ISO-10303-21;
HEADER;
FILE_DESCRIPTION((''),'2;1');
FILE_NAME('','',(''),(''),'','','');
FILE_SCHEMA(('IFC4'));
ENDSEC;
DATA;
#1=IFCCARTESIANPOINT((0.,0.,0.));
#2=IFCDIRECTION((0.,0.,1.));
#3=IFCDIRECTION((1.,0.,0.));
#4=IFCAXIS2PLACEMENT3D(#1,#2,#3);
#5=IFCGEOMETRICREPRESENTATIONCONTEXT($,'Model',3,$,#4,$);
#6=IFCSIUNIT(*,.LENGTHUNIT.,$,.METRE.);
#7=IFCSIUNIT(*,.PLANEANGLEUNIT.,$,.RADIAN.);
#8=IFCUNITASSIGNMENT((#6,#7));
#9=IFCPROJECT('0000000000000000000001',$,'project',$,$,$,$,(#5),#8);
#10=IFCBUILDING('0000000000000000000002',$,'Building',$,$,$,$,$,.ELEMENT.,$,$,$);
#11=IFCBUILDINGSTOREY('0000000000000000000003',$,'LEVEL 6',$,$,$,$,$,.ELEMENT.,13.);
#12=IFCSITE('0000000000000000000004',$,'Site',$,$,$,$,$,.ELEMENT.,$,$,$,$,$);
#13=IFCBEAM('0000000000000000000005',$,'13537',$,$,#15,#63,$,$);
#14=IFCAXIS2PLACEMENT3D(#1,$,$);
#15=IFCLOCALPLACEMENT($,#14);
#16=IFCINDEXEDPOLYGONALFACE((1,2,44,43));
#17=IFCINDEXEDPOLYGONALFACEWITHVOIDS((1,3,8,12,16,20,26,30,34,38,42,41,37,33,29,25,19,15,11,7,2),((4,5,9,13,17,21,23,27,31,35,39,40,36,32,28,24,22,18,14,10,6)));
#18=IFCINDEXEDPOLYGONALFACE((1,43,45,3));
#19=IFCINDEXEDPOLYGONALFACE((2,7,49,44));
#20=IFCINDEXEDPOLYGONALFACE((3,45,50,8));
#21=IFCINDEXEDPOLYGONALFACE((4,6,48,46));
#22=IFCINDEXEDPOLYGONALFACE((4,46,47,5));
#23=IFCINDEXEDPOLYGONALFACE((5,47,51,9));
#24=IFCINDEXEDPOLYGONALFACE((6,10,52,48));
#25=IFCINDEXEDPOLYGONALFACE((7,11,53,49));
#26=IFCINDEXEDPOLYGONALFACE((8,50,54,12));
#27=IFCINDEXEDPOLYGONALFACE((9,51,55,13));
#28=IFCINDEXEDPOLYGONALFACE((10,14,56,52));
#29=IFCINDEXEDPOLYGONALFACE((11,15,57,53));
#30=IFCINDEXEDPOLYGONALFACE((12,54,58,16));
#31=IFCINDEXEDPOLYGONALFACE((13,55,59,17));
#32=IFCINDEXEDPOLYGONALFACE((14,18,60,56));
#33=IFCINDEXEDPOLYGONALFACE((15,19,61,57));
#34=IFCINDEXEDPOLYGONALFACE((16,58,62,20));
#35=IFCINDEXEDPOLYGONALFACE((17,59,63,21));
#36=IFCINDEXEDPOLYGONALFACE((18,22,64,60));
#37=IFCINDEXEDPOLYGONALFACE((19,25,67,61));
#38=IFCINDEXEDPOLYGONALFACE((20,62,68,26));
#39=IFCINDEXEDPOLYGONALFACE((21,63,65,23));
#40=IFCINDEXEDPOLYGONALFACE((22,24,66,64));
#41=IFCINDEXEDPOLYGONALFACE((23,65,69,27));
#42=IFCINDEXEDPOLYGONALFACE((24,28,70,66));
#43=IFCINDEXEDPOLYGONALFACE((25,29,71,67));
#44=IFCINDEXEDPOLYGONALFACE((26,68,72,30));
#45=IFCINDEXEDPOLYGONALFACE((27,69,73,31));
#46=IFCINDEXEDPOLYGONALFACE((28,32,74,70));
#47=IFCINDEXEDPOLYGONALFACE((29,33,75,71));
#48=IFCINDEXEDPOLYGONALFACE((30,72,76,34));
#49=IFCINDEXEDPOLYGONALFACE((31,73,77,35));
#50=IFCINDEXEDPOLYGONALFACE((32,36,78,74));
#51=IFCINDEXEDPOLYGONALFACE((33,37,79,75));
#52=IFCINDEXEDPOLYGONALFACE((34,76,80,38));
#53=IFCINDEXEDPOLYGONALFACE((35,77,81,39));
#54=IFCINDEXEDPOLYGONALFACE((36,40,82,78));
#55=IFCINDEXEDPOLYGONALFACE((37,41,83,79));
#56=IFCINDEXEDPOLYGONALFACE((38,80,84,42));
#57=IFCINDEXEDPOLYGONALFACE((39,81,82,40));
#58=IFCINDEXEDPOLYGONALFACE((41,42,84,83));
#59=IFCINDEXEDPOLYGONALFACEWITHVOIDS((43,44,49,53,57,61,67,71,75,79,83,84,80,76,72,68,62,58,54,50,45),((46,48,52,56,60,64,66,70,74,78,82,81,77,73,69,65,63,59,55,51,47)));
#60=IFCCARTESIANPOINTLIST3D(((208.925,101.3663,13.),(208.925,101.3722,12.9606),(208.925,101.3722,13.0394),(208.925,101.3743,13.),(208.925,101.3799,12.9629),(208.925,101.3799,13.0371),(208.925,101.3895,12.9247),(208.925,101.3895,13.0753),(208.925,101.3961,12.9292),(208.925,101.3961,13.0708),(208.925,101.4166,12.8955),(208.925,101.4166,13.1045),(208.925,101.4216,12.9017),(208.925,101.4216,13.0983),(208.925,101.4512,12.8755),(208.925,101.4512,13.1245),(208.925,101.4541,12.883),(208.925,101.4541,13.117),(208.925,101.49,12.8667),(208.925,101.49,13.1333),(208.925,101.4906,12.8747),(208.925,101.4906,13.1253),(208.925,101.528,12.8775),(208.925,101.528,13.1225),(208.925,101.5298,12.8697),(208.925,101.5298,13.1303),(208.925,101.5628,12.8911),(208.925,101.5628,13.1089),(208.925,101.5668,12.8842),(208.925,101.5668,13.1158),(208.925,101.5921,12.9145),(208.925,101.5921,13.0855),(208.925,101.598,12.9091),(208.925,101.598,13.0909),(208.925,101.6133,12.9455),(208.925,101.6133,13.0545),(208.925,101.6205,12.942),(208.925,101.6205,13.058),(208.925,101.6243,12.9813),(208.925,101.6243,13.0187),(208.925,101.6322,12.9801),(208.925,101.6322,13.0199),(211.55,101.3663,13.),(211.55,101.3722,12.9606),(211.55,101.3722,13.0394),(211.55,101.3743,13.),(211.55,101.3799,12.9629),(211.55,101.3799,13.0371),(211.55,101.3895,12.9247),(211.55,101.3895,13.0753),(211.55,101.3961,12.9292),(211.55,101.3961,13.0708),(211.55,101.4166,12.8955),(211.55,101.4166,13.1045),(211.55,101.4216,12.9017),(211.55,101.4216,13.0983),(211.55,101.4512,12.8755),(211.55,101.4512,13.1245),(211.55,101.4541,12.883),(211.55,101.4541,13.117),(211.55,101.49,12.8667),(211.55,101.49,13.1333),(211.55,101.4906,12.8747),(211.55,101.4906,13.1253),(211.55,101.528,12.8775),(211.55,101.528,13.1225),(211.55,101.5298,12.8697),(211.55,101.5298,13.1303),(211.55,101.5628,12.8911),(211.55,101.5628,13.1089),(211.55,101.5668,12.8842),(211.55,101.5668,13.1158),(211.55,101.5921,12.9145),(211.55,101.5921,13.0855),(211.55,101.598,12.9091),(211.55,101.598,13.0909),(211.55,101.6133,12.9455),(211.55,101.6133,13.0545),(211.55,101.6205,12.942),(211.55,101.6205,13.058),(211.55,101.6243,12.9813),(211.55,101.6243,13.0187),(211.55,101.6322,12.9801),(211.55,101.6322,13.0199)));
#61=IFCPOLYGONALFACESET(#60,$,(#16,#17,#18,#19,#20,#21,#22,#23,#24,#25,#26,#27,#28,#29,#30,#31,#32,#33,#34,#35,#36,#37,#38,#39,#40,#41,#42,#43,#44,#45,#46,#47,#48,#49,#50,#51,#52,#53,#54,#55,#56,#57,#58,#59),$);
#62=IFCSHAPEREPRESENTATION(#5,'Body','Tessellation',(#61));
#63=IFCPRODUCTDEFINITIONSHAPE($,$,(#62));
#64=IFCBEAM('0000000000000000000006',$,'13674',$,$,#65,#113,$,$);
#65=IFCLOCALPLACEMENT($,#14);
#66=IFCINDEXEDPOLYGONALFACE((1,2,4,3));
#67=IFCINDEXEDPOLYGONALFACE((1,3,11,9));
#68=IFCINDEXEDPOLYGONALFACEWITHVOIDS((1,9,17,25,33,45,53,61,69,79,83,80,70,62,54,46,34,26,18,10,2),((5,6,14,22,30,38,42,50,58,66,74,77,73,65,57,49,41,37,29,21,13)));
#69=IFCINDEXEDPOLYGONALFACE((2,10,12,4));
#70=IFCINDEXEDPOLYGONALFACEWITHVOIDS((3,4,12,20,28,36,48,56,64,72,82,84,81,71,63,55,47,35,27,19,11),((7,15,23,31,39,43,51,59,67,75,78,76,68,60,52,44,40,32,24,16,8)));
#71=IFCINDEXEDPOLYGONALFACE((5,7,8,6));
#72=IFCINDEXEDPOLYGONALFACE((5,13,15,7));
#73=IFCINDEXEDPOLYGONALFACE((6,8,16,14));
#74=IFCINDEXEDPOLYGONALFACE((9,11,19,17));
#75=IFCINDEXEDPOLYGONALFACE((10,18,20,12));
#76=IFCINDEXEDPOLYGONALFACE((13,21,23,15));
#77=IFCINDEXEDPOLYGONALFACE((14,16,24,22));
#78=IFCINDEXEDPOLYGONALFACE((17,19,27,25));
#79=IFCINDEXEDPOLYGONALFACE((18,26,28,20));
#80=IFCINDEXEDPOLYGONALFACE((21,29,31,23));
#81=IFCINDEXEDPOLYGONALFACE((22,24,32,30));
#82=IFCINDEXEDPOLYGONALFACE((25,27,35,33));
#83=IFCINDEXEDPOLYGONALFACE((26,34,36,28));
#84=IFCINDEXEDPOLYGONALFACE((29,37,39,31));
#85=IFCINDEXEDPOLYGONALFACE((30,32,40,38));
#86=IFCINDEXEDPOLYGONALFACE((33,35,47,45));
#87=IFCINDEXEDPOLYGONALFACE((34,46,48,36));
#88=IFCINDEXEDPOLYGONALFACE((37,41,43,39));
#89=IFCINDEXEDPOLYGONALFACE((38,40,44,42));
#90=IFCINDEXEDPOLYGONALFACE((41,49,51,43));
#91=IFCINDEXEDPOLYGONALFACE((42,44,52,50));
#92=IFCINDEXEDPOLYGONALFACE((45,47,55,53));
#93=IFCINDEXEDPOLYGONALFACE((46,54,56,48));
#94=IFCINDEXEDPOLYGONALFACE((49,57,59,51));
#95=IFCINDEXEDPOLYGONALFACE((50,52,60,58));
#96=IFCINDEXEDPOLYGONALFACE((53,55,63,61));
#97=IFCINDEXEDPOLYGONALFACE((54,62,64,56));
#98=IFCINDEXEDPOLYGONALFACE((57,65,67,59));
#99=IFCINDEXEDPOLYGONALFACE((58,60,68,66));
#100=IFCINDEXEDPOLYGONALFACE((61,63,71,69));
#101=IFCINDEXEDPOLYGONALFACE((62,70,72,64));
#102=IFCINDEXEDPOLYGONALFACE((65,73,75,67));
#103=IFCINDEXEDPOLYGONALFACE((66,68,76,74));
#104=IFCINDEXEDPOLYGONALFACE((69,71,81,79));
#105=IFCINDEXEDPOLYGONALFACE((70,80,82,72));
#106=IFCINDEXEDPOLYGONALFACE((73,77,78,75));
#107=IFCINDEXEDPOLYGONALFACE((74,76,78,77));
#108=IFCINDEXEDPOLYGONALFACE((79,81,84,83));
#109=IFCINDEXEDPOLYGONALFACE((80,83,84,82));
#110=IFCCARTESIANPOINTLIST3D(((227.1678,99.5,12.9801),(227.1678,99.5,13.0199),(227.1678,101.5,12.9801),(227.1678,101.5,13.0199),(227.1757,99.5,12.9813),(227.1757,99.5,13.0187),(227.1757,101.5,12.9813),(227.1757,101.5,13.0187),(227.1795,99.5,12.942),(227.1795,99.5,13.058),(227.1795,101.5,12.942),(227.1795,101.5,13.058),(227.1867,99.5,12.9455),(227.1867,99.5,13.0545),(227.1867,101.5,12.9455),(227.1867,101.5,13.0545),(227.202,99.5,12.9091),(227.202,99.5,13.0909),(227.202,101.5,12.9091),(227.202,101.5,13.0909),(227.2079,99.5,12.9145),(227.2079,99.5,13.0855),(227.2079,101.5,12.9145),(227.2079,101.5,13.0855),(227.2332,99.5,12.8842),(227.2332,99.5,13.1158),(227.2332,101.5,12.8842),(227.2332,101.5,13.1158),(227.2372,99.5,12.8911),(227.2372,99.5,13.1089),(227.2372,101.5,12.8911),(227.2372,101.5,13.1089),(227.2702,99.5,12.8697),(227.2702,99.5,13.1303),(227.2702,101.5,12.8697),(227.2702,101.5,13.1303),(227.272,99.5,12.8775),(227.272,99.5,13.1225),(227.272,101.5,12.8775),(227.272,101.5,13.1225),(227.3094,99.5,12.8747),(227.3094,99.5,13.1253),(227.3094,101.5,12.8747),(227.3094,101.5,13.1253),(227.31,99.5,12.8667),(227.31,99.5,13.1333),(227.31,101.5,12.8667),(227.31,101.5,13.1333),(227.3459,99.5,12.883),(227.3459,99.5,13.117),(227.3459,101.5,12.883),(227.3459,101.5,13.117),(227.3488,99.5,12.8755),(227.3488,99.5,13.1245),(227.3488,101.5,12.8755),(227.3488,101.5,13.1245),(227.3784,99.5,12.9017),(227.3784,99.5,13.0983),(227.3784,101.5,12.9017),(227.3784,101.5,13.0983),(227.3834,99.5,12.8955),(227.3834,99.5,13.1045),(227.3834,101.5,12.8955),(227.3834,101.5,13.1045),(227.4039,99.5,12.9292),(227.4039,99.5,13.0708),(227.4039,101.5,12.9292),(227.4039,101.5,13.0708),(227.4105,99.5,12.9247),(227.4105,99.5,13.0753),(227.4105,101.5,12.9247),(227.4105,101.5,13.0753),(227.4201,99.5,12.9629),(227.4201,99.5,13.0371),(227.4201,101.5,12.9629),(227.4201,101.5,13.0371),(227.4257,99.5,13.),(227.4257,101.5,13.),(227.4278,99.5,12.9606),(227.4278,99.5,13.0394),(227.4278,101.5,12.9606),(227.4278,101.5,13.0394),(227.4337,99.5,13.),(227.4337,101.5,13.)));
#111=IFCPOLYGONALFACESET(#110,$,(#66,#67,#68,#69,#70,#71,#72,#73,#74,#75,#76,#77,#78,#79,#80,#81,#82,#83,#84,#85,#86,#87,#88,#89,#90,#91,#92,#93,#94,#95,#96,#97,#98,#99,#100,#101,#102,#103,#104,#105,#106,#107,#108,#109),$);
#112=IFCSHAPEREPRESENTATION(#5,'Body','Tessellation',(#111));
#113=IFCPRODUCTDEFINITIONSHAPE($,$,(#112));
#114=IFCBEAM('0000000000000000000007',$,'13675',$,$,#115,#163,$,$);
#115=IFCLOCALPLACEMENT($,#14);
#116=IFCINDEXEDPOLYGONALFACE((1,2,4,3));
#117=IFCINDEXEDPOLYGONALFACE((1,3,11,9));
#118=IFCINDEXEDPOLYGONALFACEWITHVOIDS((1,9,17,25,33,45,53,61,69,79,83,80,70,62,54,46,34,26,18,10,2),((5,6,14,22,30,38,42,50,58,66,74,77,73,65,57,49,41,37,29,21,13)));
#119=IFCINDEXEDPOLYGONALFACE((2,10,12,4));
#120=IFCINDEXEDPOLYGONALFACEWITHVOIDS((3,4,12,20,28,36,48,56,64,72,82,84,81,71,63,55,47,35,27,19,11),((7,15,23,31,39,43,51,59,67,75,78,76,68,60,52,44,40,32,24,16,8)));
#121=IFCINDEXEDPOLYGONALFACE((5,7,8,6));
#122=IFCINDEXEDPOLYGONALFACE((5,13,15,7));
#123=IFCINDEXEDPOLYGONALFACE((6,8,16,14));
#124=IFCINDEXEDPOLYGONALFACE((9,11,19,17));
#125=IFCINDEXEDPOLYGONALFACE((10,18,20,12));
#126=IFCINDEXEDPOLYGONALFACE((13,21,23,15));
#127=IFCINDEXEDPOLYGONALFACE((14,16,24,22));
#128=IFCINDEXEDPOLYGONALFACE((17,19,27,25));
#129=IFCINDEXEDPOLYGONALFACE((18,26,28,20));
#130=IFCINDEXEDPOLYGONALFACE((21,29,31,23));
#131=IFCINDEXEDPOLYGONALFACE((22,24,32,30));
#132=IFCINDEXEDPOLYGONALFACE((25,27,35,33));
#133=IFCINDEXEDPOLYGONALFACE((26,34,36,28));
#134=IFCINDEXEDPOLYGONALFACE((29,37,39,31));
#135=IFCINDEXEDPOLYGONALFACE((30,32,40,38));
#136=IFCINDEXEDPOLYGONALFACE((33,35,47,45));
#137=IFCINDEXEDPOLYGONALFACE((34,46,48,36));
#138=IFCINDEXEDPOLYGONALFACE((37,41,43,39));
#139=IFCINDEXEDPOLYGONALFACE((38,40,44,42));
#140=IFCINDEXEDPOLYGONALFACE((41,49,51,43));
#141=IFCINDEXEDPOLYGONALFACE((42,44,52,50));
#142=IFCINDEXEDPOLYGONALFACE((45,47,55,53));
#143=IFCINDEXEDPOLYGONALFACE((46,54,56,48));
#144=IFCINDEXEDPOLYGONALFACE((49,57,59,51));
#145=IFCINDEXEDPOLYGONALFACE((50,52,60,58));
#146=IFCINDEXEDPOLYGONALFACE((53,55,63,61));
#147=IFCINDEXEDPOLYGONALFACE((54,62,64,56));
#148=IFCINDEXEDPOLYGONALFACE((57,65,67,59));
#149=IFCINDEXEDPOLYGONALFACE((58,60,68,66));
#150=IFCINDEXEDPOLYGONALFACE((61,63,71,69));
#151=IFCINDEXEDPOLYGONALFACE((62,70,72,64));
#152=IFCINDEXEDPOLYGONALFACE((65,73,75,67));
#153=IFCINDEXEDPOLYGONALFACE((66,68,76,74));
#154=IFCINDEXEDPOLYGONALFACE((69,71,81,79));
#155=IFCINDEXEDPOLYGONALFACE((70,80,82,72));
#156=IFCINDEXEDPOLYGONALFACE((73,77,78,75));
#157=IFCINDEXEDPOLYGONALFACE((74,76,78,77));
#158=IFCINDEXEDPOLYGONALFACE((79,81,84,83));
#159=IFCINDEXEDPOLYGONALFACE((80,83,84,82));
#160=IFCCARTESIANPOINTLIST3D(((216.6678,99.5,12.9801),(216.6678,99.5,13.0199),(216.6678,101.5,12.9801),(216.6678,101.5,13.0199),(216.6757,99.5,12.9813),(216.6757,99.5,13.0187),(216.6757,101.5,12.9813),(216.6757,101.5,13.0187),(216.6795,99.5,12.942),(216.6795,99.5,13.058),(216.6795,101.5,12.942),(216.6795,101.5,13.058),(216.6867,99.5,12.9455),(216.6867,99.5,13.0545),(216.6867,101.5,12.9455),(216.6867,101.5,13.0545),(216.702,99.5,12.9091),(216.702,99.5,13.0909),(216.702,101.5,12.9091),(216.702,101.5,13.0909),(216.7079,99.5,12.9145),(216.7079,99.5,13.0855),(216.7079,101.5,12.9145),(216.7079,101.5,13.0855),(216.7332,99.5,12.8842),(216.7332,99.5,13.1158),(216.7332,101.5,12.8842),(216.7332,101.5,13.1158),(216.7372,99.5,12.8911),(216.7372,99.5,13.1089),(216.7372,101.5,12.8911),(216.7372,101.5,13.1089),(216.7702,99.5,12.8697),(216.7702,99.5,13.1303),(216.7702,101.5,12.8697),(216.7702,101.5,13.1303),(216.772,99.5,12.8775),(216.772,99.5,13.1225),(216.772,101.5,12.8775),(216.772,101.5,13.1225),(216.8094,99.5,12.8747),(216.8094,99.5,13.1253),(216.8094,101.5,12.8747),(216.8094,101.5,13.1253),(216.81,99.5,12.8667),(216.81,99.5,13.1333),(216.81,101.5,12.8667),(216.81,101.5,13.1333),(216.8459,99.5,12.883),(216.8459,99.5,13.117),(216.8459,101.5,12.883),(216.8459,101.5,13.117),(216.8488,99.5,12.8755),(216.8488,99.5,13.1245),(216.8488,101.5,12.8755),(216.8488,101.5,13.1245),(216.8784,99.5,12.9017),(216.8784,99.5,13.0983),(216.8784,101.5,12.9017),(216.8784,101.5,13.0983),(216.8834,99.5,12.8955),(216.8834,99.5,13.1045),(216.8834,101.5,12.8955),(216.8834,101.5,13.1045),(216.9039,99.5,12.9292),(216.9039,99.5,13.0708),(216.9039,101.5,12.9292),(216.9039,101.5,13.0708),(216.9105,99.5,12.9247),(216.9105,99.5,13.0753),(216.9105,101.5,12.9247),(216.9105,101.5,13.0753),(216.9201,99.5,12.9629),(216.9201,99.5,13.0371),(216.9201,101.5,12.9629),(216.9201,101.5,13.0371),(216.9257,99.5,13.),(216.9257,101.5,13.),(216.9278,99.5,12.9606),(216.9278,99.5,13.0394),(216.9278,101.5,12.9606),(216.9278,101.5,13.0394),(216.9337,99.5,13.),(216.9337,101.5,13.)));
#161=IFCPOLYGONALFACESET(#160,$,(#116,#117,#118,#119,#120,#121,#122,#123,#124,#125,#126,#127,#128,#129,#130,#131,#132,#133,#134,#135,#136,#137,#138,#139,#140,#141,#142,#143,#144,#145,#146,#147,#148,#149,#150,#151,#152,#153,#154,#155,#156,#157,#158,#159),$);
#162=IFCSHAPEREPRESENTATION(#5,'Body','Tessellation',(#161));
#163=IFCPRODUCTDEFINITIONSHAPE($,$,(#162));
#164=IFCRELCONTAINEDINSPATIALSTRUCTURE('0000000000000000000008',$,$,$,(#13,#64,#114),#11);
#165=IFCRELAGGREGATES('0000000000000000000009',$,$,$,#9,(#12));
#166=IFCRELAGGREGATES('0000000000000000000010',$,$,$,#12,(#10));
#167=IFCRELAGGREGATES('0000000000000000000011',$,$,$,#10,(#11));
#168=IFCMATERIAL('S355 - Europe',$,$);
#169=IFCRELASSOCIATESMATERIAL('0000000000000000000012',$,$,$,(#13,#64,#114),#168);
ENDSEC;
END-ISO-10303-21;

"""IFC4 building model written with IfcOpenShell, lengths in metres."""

from ifc_helpers import new_model, si_unit, frame, origin_with_axes, origin_2d_with_axis, place, context, project, spatial, hollow_circle, extrude, material, material_profile, profile_set, profile_usage, element, save


model = new_model("IFC4")

# Units and contexts
model_context = context("Model", 3, world=origin_with_axes())
ifc_project = project(units=[si_unit("LENGTHUNIT", "METRE"), si_unit("PLANEANGLEUNIT", "RADIAN")], contexts=[model_context])

# Site, building, storey
site = spatial("IfcSite", under=ifc_project, Name="Site", CompositionType="ELEMENT")
building = spatial("IfcBuilding", under=site, Name="Building", CompositionType="ELEMENT")
storey = spatial("IfcBuildingStorey", under=building, Name="LEVEL 6", CompositionType="ELEMENT", Elevation=13.0)

# Shared definitions
ifc_material = material(Name="S355 - Europe")

# Beams
ifc_material_profile_1 = material_profile(ifc_material, hollow_circle(Radius=0.1337, WallThickness=0.008, at=origin_2d_with_axis()))
ifc_profile_set_1 = profile_set([ifc_material_profile_1])
ifc_profile_usage_1 = profile_usage(ifc_profile_set_1, cardinal=10)
beam_1_placement = place(None, frame((211.55, 101.5, 13.0), z_axis=(-1.0, 0.0, 0.0), x_axis=(0.0, -1.0, 0.0)))
element("IfcBeam", 1, at=beam_1_placement, inside=storey, material=ifc_profile_usage_1, Name="13537", context=model_context, shape_type="SweptSolid", body=[
    extrude(hollow_circle(Radius=0.1337, WallThickness=0.008, at=origin_2d_with_axis()), origin_with_axes(), (0.0, 0.0, 1.0), 2.625),
])
ifc_material_profile_2 = material_profile(ifc_material, hollow_circle(Radius=0.1337, WallThickness=0.008, at=origin_2d_with_axis()))
ifc_profile_set_2 = profile_set([ifc_material_profile_2])
ifc_profile_usage_2 = profile_usage(ifc_profile_set_2, cardinal=10)
beam_2_placement = place(None, frame((227.3, 101.5, 13.0), z_axis=(0.0, -1.0, 0.0), x_axis=(1.0, 0.0, 0.0)))
element("IfcBeam", 2, at=beam_2_placement, inside=storey, material=ifc_profile_usage_2, Name="13674", context=model_context, shape_type="SweptSolid", body=[
    extrude(hollow_circle(Radius=0.1337, WallThickness=0.008, at=origin_2d_with_axis()), origin_with_axes(), (0.0, 0.0, 1.0), 2.0),
])
ifc_material_profile_3 = material_profile(ifc_material, hollow_circle(Radius=0.1337, WallThickness=0.008, at=origin_2d_with_axis()))
ifc_profile_set_3 = profile_set([ifc_material_profile_3])
ifc_profile_usage_3 = profile_usage(ifc_profile_set_3, cardinal=10)
beam_3_placement = place(None, frame((216.8, 101.5, 13.0), z_axis=(0.0, -1.0, 0.0), x_axis=(1.0, 0.0, 0.0)))
element("IfcBeam", 3, at=beam_3_placement, inside=storey, material=ifc_profile_usage_3, Name="13675", context=model_context, shape_type="SweptSolid", body=[
    extrude(hollow_circle(Radius=0.1337, WallThickness=0.008, at=origin_2d_with_axis()), origin_with_axes(), (0.0, 0.0, 1.0), 2.0),
])

save(model, "model.ifc")
